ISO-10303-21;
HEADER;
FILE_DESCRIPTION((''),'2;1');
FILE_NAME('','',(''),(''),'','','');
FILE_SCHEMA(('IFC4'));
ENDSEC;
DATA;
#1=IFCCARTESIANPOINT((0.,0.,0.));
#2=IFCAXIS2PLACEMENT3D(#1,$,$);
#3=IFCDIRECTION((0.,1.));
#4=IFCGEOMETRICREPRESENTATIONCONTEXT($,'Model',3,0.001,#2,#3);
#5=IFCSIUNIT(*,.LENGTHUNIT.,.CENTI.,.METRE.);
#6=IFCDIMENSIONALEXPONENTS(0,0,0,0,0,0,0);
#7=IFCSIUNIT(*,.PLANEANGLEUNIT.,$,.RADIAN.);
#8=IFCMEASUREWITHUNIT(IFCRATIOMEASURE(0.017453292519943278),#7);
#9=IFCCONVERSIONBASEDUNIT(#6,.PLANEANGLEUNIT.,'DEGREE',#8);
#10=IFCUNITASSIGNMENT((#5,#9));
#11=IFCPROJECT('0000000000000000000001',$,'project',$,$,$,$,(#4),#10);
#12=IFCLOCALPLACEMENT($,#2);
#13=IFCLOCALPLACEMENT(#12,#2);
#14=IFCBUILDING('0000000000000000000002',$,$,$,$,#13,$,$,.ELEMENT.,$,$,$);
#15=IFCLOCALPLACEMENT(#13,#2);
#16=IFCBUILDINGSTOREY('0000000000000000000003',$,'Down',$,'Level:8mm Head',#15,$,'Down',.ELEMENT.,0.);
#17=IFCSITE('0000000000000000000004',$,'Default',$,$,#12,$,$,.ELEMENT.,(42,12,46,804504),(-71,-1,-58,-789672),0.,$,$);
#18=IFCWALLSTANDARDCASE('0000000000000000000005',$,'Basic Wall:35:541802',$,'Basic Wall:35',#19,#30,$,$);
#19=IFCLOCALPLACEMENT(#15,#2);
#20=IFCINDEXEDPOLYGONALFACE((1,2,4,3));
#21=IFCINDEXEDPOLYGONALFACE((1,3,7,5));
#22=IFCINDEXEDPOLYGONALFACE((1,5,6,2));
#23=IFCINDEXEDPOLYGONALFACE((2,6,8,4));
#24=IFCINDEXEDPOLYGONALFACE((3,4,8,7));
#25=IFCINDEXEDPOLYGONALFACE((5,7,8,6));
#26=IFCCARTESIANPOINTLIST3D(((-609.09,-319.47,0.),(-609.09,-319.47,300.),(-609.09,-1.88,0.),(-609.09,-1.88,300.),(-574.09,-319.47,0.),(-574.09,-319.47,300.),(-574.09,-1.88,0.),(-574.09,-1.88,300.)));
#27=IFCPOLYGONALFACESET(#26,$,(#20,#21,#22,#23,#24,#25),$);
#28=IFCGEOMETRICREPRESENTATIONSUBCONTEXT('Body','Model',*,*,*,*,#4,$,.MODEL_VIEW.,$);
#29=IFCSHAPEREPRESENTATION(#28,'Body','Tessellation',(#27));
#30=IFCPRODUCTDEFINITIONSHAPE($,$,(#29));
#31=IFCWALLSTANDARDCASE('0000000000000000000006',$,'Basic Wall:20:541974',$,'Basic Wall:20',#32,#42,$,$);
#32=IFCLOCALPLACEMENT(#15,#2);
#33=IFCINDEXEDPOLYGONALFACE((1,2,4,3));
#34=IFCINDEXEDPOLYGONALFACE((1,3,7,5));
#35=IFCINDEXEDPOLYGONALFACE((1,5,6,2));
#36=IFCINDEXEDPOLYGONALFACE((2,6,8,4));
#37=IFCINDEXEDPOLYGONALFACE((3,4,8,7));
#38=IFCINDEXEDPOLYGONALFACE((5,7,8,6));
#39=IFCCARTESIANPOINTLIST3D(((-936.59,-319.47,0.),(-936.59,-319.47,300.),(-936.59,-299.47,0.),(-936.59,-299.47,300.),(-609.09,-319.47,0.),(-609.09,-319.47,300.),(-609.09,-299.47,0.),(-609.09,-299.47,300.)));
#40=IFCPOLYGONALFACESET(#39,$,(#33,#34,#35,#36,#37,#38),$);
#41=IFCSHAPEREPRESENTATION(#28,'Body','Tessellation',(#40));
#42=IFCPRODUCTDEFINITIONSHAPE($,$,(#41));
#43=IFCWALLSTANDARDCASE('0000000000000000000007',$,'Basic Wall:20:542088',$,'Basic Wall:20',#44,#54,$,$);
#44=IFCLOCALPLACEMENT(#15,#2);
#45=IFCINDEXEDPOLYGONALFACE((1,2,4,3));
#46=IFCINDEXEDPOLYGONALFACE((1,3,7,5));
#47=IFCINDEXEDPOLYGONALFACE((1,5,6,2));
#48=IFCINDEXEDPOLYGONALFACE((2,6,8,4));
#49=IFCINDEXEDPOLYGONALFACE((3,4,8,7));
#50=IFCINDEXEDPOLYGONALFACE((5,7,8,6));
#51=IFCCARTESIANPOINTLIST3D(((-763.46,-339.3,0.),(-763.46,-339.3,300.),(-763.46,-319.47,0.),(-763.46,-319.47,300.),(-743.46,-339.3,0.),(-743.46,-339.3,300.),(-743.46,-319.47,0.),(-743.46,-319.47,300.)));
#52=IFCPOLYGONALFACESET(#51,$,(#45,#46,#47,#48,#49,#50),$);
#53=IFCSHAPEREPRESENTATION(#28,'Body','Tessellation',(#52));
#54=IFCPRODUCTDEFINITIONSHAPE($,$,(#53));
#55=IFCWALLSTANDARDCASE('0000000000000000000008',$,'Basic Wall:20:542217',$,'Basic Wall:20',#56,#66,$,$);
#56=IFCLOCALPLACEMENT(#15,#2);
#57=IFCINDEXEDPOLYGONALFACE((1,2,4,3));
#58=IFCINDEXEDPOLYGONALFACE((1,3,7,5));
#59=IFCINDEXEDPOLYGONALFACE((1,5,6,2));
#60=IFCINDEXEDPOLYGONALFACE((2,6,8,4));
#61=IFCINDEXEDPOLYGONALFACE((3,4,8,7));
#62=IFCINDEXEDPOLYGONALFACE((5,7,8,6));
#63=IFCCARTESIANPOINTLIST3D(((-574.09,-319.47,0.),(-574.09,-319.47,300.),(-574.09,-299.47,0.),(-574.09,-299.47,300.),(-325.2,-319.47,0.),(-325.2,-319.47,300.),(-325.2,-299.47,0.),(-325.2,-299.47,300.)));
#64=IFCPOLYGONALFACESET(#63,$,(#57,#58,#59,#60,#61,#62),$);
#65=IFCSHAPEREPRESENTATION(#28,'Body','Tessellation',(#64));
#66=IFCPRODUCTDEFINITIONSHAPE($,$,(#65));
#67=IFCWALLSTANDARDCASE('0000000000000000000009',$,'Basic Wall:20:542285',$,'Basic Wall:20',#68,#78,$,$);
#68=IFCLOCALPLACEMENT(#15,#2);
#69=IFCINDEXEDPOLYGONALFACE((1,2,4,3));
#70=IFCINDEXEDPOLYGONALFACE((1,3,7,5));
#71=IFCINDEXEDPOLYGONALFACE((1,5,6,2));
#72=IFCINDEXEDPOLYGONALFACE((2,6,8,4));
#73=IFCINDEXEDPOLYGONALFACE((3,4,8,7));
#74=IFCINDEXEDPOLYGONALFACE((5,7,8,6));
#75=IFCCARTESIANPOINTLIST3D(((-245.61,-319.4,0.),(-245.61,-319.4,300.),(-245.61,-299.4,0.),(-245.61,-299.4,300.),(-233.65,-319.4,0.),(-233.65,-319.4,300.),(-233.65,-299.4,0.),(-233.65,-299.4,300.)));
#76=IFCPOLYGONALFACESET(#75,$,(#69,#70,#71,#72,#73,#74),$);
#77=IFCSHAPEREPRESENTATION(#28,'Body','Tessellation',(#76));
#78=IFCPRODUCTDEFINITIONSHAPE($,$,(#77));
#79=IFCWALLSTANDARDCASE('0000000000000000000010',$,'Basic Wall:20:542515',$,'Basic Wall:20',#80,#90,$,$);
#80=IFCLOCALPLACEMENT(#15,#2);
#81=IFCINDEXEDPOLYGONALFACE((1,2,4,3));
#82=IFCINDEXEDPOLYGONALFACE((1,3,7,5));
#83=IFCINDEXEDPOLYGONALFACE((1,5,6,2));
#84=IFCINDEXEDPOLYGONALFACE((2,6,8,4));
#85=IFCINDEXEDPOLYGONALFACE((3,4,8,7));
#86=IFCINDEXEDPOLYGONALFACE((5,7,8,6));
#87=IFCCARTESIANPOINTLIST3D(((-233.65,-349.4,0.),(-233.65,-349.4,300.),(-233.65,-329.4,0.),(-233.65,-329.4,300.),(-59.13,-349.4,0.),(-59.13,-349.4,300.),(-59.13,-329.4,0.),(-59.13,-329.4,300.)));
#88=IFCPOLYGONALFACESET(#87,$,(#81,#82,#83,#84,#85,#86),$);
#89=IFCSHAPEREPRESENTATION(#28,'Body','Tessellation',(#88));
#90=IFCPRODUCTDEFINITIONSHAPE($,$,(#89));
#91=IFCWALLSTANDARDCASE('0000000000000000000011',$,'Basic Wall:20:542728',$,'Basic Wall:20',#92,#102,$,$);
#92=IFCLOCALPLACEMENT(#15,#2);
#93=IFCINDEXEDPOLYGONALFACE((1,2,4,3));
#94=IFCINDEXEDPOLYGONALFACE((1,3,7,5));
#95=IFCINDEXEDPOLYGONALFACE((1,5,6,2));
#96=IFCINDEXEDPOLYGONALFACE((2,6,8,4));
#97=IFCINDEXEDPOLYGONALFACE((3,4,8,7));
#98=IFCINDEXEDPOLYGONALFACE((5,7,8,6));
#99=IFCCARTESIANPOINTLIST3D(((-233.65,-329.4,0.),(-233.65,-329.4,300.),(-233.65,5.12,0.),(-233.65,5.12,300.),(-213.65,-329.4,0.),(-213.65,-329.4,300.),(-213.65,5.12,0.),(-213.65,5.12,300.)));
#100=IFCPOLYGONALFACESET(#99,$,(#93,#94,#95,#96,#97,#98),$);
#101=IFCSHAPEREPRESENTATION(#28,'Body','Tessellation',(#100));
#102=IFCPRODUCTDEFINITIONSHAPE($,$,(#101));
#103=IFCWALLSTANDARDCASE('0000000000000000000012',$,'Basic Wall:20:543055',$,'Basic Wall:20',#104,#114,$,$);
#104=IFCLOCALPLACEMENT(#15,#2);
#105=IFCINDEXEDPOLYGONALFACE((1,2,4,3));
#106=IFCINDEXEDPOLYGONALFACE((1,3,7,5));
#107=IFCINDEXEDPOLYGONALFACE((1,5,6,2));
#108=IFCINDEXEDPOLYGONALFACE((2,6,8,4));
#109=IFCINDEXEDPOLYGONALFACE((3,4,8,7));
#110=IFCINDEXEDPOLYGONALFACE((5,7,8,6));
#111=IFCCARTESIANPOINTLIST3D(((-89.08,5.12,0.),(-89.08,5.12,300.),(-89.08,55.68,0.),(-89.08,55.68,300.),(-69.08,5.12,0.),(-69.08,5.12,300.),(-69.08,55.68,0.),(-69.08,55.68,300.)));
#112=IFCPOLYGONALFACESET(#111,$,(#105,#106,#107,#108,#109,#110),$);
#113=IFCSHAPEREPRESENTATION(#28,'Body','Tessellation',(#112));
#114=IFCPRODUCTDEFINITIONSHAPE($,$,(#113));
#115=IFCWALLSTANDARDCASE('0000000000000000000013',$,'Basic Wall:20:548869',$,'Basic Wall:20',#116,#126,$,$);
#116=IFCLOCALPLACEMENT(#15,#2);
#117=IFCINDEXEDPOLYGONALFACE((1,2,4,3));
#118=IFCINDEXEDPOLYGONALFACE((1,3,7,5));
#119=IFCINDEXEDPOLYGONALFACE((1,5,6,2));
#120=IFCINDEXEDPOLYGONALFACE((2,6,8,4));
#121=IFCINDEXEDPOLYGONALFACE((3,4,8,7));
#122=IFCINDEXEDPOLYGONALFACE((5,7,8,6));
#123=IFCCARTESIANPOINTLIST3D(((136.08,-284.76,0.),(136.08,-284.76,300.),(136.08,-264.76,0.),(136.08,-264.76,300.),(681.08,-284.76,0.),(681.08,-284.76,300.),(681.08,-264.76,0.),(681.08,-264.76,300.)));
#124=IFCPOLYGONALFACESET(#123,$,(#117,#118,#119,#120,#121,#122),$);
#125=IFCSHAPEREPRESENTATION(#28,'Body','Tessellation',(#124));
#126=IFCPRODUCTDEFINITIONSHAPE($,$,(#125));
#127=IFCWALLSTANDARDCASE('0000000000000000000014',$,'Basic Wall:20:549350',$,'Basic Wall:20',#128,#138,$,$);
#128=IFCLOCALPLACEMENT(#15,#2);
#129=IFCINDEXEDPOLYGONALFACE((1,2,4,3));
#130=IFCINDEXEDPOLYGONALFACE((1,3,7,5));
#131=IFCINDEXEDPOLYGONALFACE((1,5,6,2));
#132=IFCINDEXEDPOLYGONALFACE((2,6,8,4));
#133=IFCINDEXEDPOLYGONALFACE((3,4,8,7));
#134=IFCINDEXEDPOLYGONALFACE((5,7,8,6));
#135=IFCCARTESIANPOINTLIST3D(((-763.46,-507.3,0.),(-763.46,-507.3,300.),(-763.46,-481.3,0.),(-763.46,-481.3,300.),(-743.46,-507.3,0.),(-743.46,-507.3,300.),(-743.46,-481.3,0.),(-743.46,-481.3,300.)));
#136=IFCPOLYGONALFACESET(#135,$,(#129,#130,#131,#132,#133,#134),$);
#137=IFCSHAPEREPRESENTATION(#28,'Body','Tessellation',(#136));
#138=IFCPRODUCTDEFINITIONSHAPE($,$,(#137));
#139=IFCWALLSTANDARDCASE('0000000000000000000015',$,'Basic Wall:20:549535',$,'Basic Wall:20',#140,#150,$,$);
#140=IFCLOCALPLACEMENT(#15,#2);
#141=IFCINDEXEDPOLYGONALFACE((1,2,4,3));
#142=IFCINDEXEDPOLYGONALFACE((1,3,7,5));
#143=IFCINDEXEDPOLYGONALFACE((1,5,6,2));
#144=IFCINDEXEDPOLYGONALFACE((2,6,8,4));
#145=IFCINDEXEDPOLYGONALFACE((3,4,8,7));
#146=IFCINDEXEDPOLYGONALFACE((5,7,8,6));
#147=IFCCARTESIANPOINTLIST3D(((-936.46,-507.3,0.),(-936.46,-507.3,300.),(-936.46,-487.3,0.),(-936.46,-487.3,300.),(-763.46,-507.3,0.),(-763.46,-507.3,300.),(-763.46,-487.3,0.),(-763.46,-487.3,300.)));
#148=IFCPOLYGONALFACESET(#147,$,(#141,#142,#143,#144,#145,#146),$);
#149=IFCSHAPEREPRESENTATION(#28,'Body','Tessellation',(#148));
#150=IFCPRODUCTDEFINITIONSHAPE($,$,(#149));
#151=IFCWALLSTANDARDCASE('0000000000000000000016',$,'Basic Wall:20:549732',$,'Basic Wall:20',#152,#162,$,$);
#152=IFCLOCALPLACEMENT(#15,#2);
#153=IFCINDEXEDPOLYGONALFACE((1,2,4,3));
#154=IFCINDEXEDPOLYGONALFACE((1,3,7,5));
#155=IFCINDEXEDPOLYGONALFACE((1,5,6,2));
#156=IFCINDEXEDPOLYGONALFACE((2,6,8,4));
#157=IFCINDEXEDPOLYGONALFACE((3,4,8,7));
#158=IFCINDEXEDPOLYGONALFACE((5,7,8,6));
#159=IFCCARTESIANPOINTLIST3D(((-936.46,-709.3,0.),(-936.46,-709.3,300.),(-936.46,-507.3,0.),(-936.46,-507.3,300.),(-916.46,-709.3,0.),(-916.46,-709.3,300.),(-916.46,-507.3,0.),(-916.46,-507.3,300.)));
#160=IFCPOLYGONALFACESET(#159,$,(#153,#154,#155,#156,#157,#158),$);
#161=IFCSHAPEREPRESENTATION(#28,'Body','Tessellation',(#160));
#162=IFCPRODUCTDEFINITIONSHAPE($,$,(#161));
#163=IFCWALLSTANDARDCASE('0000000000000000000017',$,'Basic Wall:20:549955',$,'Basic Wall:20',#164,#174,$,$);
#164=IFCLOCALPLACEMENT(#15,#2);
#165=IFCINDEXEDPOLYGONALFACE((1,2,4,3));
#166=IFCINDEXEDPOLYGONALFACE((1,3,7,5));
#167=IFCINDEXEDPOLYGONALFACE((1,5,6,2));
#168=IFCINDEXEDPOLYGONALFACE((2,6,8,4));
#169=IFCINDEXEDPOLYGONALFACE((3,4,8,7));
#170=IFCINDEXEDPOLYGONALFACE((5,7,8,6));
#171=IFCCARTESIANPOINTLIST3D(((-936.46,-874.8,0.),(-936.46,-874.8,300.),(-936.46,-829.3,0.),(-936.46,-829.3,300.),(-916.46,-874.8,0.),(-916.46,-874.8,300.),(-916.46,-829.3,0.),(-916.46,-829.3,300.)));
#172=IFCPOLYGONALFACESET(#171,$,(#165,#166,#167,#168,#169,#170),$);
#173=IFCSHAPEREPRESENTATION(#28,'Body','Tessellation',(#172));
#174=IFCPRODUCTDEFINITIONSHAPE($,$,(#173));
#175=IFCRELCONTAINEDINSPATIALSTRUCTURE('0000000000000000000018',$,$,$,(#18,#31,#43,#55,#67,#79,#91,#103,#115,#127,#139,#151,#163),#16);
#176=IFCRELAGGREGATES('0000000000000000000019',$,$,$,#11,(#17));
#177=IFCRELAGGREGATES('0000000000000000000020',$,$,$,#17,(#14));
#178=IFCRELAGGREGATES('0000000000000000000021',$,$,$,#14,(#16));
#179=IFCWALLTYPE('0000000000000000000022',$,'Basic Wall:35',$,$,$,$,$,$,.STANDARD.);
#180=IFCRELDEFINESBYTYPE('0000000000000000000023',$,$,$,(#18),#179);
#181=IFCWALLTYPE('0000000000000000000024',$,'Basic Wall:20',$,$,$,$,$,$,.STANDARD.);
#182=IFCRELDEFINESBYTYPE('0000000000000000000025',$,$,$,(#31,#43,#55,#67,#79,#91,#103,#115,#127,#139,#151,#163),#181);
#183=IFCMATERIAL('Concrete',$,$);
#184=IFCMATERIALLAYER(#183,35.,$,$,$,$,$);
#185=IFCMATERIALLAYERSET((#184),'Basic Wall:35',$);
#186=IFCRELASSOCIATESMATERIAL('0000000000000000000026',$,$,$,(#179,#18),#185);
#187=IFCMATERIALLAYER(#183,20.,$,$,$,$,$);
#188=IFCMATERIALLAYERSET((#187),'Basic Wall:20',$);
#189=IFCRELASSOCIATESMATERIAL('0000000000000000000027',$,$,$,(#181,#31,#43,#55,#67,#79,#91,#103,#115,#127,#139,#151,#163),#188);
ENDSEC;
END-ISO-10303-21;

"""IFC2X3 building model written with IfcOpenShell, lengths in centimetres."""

from ifc_helpers import new_model, entity, si_unit, converted_unit, direction, frame, frame_2d, origin, place, context, subcontext, project, spatial, rectangle, extrude, material, layer, layer_set, layer_usage, type_object, element, save


model = new_model("IFC2X3")

# Units and contexts
model_context = context("Model", 3, precision=0.001, world=origin(), true_north=direction((0.0, 1.0)))
body_context = subcontext(model_context, "Body", "Model", "MODEL_VIEW")
ifc_project = project(units=[si_unit("LENGTHUNIT", "METRE", prefix="CENTI"), converted_unit("PLANEANGLEUNIT", "DEGREE", entity("IfcRatioMeasure", 0.017453292519943278), si_unit("PLANEANGLEUNIT", "RADIAN"), dimensions=[0, 0, 0, 0, 0, 0, 0])], contexts=[model_context])

# Site, building, storey
site_placement = place(None, origin())
site = spatial("IfcSite", under=ifc_project, at=site_placement, Name="Default", CompositionType="ELEMENT", RefLatitude=(42, 12, 46, 804504), RefLongitude=(-71, -1, -58, -789672), RefElevation=0.0)
building_placement = place(site_placement, origin())
building = spatial("IfcBuilding", under=site, at=building_placement, CompositionType="ELEMENT")
storey_placement = place(building_placement, origin())
storey = spatial("IfcBuildingStorey", under=building, at=storey_placement, Name="Down", ObjectType="Level:8mm Head", LongName="Down", CompositionType="ELEMENT", Elevation=0.0)

# Walls
ifc_material = material(Name="Concrete")
ifc_layer_1 = layer(ifc_material, 35.0)
ifc_layer_set_1 = layer_set([ifc_layer_1], Name="Basic Wall:35")
ifc_layer_usage_1 = layer_usage(ifc_layer_set_1, "AXIS2", "POSITIVE", -17.5)
wall_type_1 = type_object("IfcWallType", Name="Basic Wall:35", PredefinedType="STANDARD", material=ifc_layer_set_1)
wall_1_placement = place(storey_placement, frame((-591.59, -1.88, 0.0), z_axis=(0.0, 0.0, 1.0), x_axis=(0.0, -1.0, 0.0)))
element("IfcWallStandardCase", 1, at=wall_1_placement, inside=storey, type_object=wall_type_1, material=ifc_layer_usage_1, Name="Basic Wall:35:541802", ObjectType="Basic Wall:35", context=body_context, shape_type="SweptSolid", body=[
    extrude(rectangle(XDim=317.59, YDim=35.0, at=frame_2d((158.8, 0.0), x_axis=(-1.0, 0.0))), origin(), (0.0, 0.0, 1.0), 300.0),
])
ifc_layer_2 = layer(ifc_material, 20.0)
ifc_layer_set_2 = layer_set([ifc_layer_2], Name="Basic Wall:20")
ifc_layer_usage_2 = layer_usage(ifc_layer_set_2, "AXIS2", "NEGATIVE", 10.0)
wall_type_2 = type_object("IfcWallType", Name="Basic Wall:20", PredefinedType="STANDARD", material=ifc_layer_set_2)
wall_2_placement = place(storey_placement, frame((-609.09, -309.47, 0.0), z_axis=(0.0, 0.0, 1.0), x_axis=(-1.0, 0.0, 0.0)))
element("IfcWallStandardCase", 2, at=wall_2_placement, inside=storey, type_object=wall_type_2, material=ifc_layer_usage_2, Name="Basic Wall:20:541974", ObjectType="Basic Wall:20", context=body_context, shape_type="SweptSolid", body=[
    extrude(rectangle(XDim=327.5, YDim=20.0, at=frame_2d((163.75, 0.0), x_axis=(-1.0, 0.0))), origin(), (0.0, 0.0, 1.0), 300.0),
])
ifc_layer_usage_3 = layer_usage(ifc_layer_set_2, "AXIS2", "NEGATIVE", 10.0)
wall_3_placement = place(storey_placement, frame((-753.46, -319.47, 0.0), z_axis=(0.0, 0.0, 1.0), x_axis=(0.0, -1.0, 0.0)))
element("IfcWallStandardCase", 3, at=wall_3_placement, inside=storey, type_object=wall_type_2, material=ifc_layer_usage_3, Name="Basic Wall:20:542088", ObjectType="Basic Wall:20", context=body_context, shape_type="SweptSolid", body=[
    extrude(rectangle(XDim=19.82, YDim=20.0, at=frame_2d((9.91, 0.0), x_axis=(-1.0, 0.0))), origin(), (0.0, 0.0, 1.0), 300.0),
])
ifc_layer_usage_4 = layer_usage(ifc_layer_set_2, "AXIS2", "POSITIVE", -10.0)
wall_4_placement = place(storey_placement, frame((-574.09, -309.47, 0.0)))
element("IfcWallStandardCase", 4, at=wall_4_placement, inside=storey, type_object=wall_type_2, material=ifc_layer_usage_4, Name="Basic Wall:20:542217", ObjectType="Basic Wall:20", context=body_context, shape_type="SweptSolid", body=[
    extrude(rectangle(XDim=248.89, YDim=20.0, at=frame_2d((124.45, 0.0), x_axis=(-1.0, 0.0))), origin(), (0.0, 0.0, 1.0), 300.0),
])
ifc_layer_usage_5 = layer_usage(ifc_layer_set_2, "AXIS2", "POSITIVE", -10.0)
wall_5_placement = place(storey_placement, frame((-245.61, -309.4, 0.0)))
element("IfcWallStandardCase", 5, at=wall_5_placement, inside=storey, type_object=wall_type_2, material=ifc_layer_usage_5, Name="Basic Wall:20:542285", ObjectType="Basic Wall:20", context=body_context, shape_type="SweptSolid", body=[
    extrude(rectangle(XDim=11.96, YDim=20.0, at=frame_2d((5.98, 0.0), x_axis=(-1.0, 0.0))), origin(), (0.0, 0.0, 1.0), 300.0),
])
ifc_layer_usage_6 = layer_usage(ifc_layer_set_2, "AXIS2", "POSITIVE", -10.0)
wall_6_placement = place(storey_placement, frame((-233.65, -339.4, 0.0)))
element("IfcWallStandardCase", 6, at=wall_6_placement, inside=storey, type_object=wall_type_2, material=ifc_layer_usage_6, Name="Basic Wall:20:542515", ObjectType="Basic Wall:20", context=body_context, shape_type="SweptSolid", body=[
    extrude(rectangle(XDim=174.52, YDim=20.0, at=frame_2d((87.26, 0.0), x_axis=(-1.0, 0.0))), origin(), (0.0, 0.0, 1.0), 300.0),
])
ifc_layer_usage_7 = layer_usage(ifc_layer_set_2, "AXIS2", "POSITIVE", -10.0)
wall_7_placement = place(storey_placement, frame((-223.65, -329.4, 0.0), z_axis=(0.0, 0.0, 1.0), x_axis=(0.0, 1.0, 0.0)))
element("IfcWallStandardCase", 7, at=wall_7_placement, inside=storey, type_object=wall_type_2, material=ifc_layer_usage_7, Name="Basic Wall:20:542728", ObjectType="Basic Wall:20", context=body_context, shape_type="SweptSolid", body=[
    extrude(rectangle(XDim=334.52, YDim=20.0, at=frame_2d((167.26, 0.0), x_axis=(-1.0, 0.0))), origin(), (0.0, 0.0, 1.0), 300.0),
])
ifc_layer_usage_8 = layer_usage(ifc_layer_set_2, "AXIS2", "POSITIVE", -10.0)
wall_8_placement = place(storey_placement, frame((-79.08, 5.12, 0.0), z_axis=(0.0, 0.0, 1.0), x_axis=(0.0, 1.0, 0.0)))
element("IfcWallStandardCase", 8, at=wall_8_placement, inside=storey, type_object=wall_type_2, material=ifc_layer_usage_8, Name="Basic Wall:20:543055", ObjectType="Basic Wall:20", context=body_context, shape_type="SweptSolid", body=[
    extrude(rectangle(XDim=50.56, YDim=20.0, at=frame_2d((25.28, 0.0), x_axis=(-1.0, 0.0))), origin(), (0.0, 0.0, 1.0), 300.0),
])
ifc_layer_usage_9 = layer_usage(ifc_layer_set_2, "AXIS2", "POSITIVE", -10.0)
wall_9_placement = place(storey_placement, frame((136.08, -274.76, 0.0)))
element("IfcWallStandardCase", 9, at=wall_9_placement, inside=storey, type_object=wall_type_2, material=ifc_layer_usage_9, Name="Basic Wall:20:548869", ObjectType="Basic Wall:20", context=body_context, shape_type="SweptSolid", body=[
    extrude(rectangle(XDim=545.0, YDim=20.0, at=frame_2d((272.5, 0.0), x_axis=(-1.0, 0.0))), origin(), (0.0, 0.0, 1.0), 300.0),
])
ifc_layer_usage_10 = layer_usage(ifc_layer_set_2, "AXIS2", "NEGATIVE", 10.0)
wall_10_placement = place(storey_placement, frame((-753.46, -481.3, 0.0), z_axis=(0.0, 0.0, 1.0), x_axis=(0.0, -1.0, 0.0)))
element("IfcWallStandardCase", 10, at=wall_10_placement, inside=storey, type_object=wall_type_2, material=ifc_layer_usage_10, Name="Basic Wall:20:549350", ObjectType="Basic Wall:20", context=body_context, shape_type="SweptSolid", body=[
    extrude(rectangle(XDim=26.0, YDim=20.0, at=frame_2d((13.0, 0.0), x_axis=(-1.0, 0.0))), origin(), (0.0, 0.0, 1.0), 300.0),
])
ifc_layer_usage_11 = layer_usage(ifc_layer_set_2, "AXIS2", "NEGATIVE", 10.0)
wall_11_placement = place(storey_placement, frame((-763.46, -497.3, 0.0), z_axis=(0.0, 0.0, 1.0), x_axis=(-1.0, 0.0, 0.0)))
element("IfcWallStandardCase", 11, at=wall_11_placement, inside=storey, type_object=wall_type_2, material=ifc_layer_usage_11, Name="Basic Wall:20:549535", ObjectType="Basic Wall:20", context=body_context, shape_type="SweptSolid", body=[
    extrude(rectangle(XDim=173.0, YDim=20.0, at=frame_2d((86.5, 0.0), x_axis=(-1.0, 0.0))), origin(), (0.0, 0.0, 1.0), 300.0),
])
ifc_layer_usage_12 = layer_usage(ifc_layer_set_2, "AXIS2", "POSITIVE", -10.0)
wall_12_placement = place(storey_placement, frame((-926.46, -507.3, 0.0), z_axis=(0.0, 0.0, 1.0), x_axis=(0.0, -1.0, 0.0)))
element("IfcWallStandardCase", 12, at=wall_12_placement, inside=storey, type_object=wall_type_2, material=ifc_layer_usage_12, Name="Basic Wall:20:549732", ObjectType="Basic Wall:20", context=body_context, shape_type="SweptSolid", body=[
    extrude(rectangle(XDim=202.0, YDim=20.0, at=frame_2d((101.0, 0.0), x_axis=(-1.0, 0.0))), origin(), (0.0, 0.0, 1.0), 300.0),
])
ifc_layer_usage_13 = layer_usage(ifc_layer_set_2, "AXIS2", "POSITIVE", -10.0)
wall_13_placement = place(storey_placement, frame((-926.46, -829.3, 0.0), z_axis=(0.0, 0.0, 1.0), x_axis=(0.0, -1.0, 0.0)))
element("IfcWallStandardCase", 13, at=wall_13_placement, inside=storey, type_object=wall_type_2, material=ifc_layer_usage_13, Name="Basic Wall:20:549955", ObjectType="Basic Wall:20", context=body_context, shape_type="SweptSolid", body=[
    extrude(rectangle(XDim=45.5, YDim=20.0, at=frame_2d((22.75, 0.0), x_axis=(-1.0, 0.0))), origin(), (0.0, 0.0, 1.0), 300.0),
])

save(model, "model.ifc")
